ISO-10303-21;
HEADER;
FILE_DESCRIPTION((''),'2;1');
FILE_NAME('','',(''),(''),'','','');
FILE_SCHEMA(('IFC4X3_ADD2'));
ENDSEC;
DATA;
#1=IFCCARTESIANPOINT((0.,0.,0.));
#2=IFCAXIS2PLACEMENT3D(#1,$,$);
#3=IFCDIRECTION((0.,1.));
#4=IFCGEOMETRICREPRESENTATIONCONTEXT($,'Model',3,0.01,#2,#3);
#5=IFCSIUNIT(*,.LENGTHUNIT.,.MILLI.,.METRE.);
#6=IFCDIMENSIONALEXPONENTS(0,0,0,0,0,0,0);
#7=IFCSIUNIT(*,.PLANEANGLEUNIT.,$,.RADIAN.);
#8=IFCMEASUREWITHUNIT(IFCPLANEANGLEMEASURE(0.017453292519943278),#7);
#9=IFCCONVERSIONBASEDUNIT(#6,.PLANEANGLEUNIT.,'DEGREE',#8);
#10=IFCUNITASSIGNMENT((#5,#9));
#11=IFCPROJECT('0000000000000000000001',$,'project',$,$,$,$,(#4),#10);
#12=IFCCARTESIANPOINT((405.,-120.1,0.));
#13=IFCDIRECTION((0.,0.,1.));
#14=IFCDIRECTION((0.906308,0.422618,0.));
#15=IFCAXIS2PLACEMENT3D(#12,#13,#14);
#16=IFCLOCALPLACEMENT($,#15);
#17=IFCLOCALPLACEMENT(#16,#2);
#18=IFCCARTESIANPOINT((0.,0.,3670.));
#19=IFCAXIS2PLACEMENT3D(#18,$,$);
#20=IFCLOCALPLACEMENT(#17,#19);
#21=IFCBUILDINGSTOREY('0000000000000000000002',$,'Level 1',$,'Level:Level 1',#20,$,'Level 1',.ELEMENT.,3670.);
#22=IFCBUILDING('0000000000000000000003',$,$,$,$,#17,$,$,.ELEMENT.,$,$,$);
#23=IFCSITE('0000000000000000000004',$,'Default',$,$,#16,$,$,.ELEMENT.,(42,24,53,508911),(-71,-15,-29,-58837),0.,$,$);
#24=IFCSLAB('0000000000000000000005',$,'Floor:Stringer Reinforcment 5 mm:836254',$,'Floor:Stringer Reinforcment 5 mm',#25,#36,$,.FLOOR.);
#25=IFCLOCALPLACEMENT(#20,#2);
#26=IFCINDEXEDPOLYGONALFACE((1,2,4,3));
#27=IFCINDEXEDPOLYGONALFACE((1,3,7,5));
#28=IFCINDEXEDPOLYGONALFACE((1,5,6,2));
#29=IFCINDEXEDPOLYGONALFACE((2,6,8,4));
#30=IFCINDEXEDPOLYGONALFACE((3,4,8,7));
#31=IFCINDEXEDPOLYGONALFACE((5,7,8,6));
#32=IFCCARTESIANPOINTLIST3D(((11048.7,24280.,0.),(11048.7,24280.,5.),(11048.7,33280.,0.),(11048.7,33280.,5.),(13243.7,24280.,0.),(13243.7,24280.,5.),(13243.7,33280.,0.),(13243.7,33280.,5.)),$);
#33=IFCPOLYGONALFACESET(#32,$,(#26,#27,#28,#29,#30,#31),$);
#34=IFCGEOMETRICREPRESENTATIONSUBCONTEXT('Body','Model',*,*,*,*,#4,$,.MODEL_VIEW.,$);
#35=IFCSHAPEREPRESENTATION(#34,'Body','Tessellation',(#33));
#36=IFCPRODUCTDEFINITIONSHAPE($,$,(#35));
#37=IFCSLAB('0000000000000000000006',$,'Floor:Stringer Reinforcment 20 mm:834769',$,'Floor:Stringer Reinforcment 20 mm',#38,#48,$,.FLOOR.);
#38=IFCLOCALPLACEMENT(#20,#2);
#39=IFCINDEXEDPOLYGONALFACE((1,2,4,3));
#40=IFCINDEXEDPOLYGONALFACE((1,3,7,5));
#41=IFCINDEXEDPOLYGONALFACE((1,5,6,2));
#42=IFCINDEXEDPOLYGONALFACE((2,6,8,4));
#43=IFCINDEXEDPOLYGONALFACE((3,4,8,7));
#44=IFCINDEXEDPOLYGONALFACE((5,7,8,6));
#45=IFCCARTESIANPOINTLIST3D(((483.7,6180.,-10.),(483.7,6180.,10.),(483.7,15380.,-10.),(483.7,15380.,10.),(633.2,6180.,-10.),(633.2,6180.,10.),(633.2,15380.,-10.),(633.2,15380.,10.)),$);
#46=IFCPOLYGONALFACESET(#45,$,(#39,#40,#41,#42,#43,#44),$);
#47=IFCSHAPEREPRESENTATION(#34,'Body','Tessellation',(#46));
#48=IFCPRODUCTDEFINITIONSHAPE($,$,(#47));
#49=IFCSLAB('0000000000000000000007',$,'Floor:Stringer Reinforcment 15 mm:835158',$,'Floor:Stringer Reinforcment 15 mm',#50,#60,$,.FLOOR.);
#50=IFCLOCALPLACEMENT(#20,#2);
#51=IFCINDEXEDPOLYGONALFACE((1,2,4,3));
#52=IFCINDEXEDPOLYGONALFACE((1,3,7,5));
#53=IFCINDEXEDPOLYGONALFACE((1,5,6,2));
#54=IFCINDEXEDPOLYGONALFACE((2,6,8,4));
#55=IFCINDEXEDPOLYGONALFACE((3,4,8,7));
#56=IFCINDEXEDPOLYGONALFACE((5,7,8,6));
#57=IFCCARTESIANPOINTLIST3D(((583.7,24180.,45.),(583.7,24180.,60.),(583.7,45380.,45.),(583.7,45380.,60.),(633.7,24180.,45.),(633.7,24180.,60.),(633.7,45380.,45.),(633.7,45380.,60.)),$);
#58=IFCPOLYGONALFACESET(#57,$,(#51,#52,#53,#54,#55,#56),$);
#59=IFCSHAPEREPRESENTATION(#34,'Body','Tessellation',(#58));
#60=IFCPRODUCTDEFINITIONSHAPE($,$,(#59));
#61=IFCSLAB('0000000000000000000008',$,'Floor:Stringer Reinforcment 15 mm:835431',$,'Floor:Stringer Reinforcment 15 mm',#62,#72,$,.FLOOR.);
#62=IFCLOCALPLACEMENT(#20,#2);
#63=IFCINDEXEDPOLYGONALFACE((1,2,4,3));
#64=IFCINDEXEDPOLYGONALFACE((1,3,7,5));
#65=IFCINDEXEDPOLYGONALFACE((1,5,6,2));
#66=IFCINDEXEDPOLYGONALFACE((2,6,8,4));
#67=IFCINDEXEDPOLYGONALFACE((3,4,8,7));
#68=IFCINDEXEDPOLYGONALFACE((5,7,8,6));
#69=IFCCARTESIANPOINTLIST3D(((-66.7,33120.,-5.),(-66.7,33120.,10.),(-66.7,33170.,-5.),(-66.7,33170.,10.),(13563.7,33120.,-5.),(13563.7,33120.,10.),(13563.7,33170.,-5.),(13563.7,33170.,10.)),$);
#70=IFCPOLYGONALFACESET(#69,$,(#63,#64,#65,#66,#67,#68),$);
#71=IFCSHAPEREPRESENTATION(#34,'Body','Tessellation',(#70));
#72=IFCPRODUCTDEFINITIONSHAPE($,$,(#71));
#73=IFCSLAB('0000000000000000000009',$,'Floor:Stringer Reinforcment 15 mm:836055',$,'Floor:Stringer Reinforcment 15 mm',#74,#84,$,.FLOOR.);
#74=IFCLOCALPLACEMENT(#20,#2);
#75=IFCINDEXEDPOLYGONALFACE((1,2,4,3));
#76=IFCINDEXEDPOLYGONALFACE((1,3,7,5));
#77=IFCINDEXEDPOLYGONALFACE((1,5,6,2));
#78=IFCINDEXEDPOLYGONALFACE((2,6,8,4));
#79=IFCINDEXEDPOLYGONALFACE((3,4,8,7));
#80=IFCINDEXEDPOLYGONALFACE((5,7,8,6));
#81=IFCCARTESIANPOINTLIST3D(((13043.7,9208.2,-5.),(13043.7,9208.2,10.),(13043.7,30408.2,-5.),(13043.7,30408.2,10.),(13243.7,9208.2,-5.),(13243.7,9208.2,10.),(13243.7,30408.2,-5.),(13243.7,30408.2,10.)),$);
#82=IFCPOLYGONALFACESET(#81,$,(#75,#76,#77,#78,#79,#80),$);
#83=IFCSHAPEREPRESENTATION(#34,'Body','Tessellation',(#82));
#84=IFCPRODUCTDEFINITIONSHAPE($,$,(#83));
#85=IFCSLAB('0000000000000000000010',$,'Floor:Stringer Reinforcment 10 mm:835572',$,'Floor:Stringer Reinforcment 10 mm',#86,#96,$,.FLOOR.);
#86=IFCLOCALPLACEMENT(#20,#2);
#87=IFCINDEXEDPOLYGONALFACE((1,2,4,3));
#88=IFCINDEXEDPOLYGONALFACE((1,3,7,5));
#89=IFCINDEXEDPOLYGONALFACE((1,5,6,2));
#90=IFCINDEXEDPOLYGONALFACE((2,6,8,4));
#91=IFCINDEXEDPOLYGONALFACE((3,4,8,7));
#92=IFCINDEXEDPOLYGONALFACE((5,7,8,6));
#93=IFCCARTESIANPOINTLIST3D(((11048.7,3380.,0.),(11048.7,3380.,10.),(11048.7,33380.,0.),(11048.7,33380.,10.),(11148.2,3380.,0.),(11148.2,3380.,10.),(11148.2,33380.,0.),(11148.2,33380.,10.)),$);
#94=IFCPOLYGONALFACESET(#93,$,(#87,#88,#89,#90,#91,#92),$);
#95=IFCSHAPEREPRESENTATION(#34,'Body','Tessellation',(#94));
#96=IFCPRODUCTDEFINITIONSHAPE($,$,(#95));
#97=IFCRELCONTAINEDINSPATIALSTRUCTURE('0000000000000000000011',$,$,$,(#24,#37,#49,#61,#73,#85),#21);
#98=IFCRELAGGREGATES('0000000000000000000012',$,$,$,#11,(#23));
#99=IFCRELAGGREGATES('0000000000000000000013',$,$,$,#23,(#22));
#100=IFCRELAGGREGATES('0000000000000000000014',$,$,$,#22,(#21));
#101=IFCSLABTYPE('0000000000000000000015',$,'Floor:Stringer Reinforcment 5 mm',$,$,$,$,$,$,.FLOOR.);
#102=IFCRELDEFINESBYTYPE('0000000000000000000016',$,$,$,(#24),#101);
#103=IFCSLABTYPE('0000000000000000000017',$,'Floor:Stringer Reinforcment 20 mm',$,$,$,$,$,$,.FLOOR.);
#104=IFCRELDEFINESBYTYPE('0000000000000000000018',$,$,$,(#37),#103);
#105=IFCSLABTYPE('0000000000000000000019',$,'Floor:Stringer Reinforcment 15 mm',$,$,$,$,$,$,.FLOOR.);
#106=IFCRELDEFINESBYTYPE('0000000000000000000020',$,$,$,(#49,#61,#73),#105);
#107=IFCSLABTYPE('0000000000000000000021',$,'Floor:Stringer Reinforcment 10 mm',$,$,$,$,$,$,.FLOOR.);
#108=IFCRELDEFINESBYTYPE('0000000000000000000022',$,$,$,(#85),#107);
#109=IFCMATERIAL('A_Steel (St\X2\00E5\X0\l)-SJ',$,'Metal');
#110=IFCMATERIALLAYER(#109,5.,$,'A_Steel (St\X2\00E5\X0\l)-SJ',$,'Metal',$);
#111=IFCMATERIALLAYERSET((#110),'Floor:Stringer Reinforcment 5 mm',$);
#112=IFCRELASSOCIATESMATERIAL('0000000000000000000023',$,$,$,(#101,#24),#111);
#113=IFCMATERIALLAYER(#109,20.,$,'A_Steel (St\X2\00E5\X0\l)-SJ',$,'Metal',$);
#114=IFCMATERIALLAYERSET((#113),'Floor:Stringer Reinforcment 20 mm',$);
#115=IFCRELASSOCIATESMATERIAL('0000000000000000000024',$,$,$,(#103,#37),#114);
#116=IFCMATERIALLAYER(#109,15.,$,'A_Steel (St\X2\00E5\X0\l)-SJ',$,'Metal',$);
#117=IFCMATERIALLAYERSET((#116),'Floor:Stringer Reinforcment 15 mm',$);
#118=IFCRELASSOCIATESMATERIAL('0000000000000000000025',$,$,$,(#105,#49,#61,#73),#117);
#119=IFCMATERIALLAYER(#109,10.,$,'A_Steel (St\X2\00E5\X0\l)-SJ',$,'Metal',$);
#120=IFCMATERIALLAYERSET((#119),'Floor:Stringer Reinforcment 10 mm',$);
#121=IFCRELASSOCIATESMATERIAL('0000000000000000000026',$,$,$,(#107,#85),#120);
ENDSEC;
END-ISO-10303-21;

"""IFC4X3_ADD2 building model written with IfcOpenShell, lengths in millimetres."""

from ifc_helpers import new_model, entity, si_unit, converted_unit, direction, frame, frame_2d, origin, origin_2d_with_axis, place, context, subcontext, project, spatial, rectangle, extrude, material, layer, layer_set, layer_usage, type_object, element, save


model = new_model("IFC4X3_ADD2")

# Units and contexts
model_context = context("Model", 3, precision=0.01, world=origin(), true_north=direction((0.0, 1.0)))
body_context = subcontext(model_context, "Body", "Model", "MODEL_VIEW")
ifc_project = project(units=[si_unit("LENGTHUNIT", "METRE", prefix="MILLI"), converted_unit("PLANEANGLEUNIT", "DEGREE", entity("IfcPlaneAngleMeasure", 0.017453292519943278), si_unit("PLANEANGLEUNIT", "RADIAN"), dimensions=[0, 0, 0, 0, 0, 0, 0])], contexts=[model_context])

# Site, building, storey
site_placement = place(None, frame((405.0, -120.1, 0.0), z_axis=(0.0, 0.0, 1.0), x_axis=(0.906308, 0.422618, 0.0)))
site = spatial("IfcSite", under=ifc_project, at=site_placement, Name="Default", CompositionType="ELEMENT", RefLatitude=(42, 24, 53, 508911), RefLongitude=(-71, -15, -29, -58837), RefElevation=0.0)
building_placement = place(site_placement, origin())
building = spatial("IfcBuilding", under=site, at=building_placement, CompositionType="ELEMENT")
storey_placement = place(building_placement, frame((0.0, 0.0, 3670.0)))
storey = spatial("IfcBuildingStorey", under=building, at=storey_placement, Name="Level 1", ObjectType="Level:Level 1", LongName="Level 1", CompositionType="ELEMENT", Elevation=3670.0)

# Slabs
ifc_material_1 = material(Name="A_Steel (Stål)-SJ", Category="Metal")
ifc_layer_1 = layer(ifc_material_1, 5.0, Name="A_Steel (Stål)-SJ", Category="Metal")
ifc_layer_set_1 = layer_set([ifc_layer_1], Name="Floor:Stringer Reinforcment 5 mm")
slab_type_1 = type_object("IfcSlabType", Name="Floor:Stringer Reinforcment 5 mm", PredefinedType="FLOOR", material=ifc_layer_set_1)
ifc_layer_usage_1 = layer_usage(ifc_layer_set_1, "AXIS3", "POSITIVE", 0.0)
slab_1_placement = place(storey_placement, origin())
element("IfcSlab", 1, at=slab_1_placement, inside=storey, type_object=slab_type_1, material=ifc_layer_usage_1, Name="Floor:Stringer Reinforcment 5 mm:836254", ObjectType="Floor:Stringer Reinforcment 5 mm", PredefinedType="FLOOR", context=body_context, shape_type="SweptSolid", body=[
    extrude(rectangle(XDim=9000.0, YDim=2195.0, at=frame_2d((0.0, 0.0), x_axis=(1.0, 0.0))), frame((12146.2, 28780.0, 5.0), z_axis=(0.0, 0.0, -1.0), x_axis=(0.0, 1.0, 0.0)), (0.0, 0.0, 1.0), 5.0),
])
ifc_layer_2 = layer(ifc_material_1, 20.0, Name="A_Steel (Stål)-SJ", Category="Metal")
ifc_layer_set_2 = layer_set([ifc_layer_2], Name="Floor:Stringer Reinforcment 20 mm")
ifc_layer_usage_2 = layer_usage(ifc_layer_set_2, "AXIS3", "POSITIVE", 0.0)
slab_type_2 = type_object("IfcSlabType", Name="Floor:Stringer Reinforcment 20 mm", PredefinedType="FLOOR", material=ifc_layer_set_2)
slab_2_placement = place(storey_placement, origin())
element("IfcSlab", 2, at=slab_2_placement, inside=storey, type_object=slab_type_2, material=ifc_layer_usage_2, Name="Floor:Stringer Reinforcment 20 mm:834769", ObjectType="Floor:Stringer Reinforcment 20 mm", PredefinedType="FLOOR", context=body_context, shape_type="SweptSolid", body=[
    extrude(rectangle(XDim=9200.0, YDim=149.5, at=frame_2d((0.0, 0.0), x_axis=(1.0, 0.0))), frame((558.5, 10780.0, 10.0), z_axis=(0.0, 0.0, -1.0), x_axis=(0.0, 1.0, 0.0)), (0.0, 0.0, 1.0), 20.0),
])
ifc_layer_3 = layer(ifc_material_1, 15.0, Name="A_Steel (Stål)-SJ", Category="Metal")
ifc_layer_set_3 = layer_set([ifc_layer_3], Name="Floor:Stringer Reinforcment 15 mm")
ifc_layer_usage_3 = layer_usage(ifc_layer_set_3, "AXIS3", "POSITIVE", 0.0)
slab_type_3 = type_object("IfcSlabType", Name="Floor:Stringer Reinforcment 15 mm", PredefinedType="FLOOR", material=ifc_layer_set_3)
slab_3_placement = place(storey_placement, origin())
element("IfcSlab", 3, at=slab_3_placement, inside=storey, type_object=slab_type_3, material=ifc_layer_usage_3, Name="Floor:Stringer Reinforcment 15 mm:835158", ObjectType="Floor:Stringer Reinforcment 15 mm", PredefinedType="FLOOR", context=body_context, shape_type="SweptSolid", body=[
    extrude(rectangle(XDim=21200.0, YDim=50.0, at=frame_2d((0.0, 0.0), x_axis=(1.0, 0.0))), frame((608.7, 34780.0, 60.0), z_axis=(0.0, 0.0, -1.0), x_axis=(0.0, 1.0, 0.0)), (0.0, 0.0, 1.0), 15.0),
])
ifc_layer_usage_4 = layer_usage(ifc_layer_set_3, "AXIS3", "POSITIVE", 0.0)
slab_4_placement = place(storey_placement, origin())
element("IfcSlab", 4, at=slab_4_placement, inside=storey, type_object=slab_type_3, material=ifc_layer_usage_4, Name="Floor:Stringer Reinforcment 15 mm:835431", ObjectType="Floor:Stringer Reinforcment 15 mm", PredefinedType="FLOOR", context=body_context, shape_type="SweptSolid", body=[
    extrude(rectangle(XDim=50.0, YDim=13630.4, at=frame_2d((0.0, 0.0), x_axis=(1.0, 0.0))), frame((6748.5, 33145.0, 10.0), z_axis=(0.0, 0.0, -1.0), x_axis=(0.0, 1.0, 0.0)), (0.0, 0.0, 1.0), 15.0),
])
ifc_layer_usage_5 = layer_usage(ifc_layer_set_3, "AXIS3", "POSITIVE", 0.0)
slab_5_placement = place(storey_placement, origin())
element("IfcSlab", 5, at=slab_5_placement, inside=storey, type_object=slab_type_3, material=ifc_layer_usage_5, Name="Floor:Stringer Reinforcment 15 mm:836055", ObjectType="Floor:Stringer Reinforcment 15 mm", PredefinedType="FLOOR", context=body_context, shape_type="SweptSolid", body=[
    extrude(rectangle(XDim=21200.0, YDim=200.0, at=origin_2d_with_axis()), frame((13143.7, 19808.2, 10.0), z_axis=(0.0, 0.0, -1.0), x_axis=(0.0, 1.0, 0.0)), (0.0, 0.0, 1.0), 15.0),
])
ifc_layer_4 = layer(ifc_material_1, 10.0, Name="A_Steel (Stål)-SJ", Category="Metal")
ifc_layer_set_4 = layer_set([ifc_layer_4], Name="Floor:Stringer Reinforcment 10 mm")
ifc_layer_usage_6 = layer_usage(ifc_layer_set_4, "AXIS3", "POSITIVE", 0.0)
slab_type_4 = type_object("IfcSlabType", Name="Floor:Stringer Reinforcment 10 mm", PredefinedType="FLOOR", material=ifc_layer_set_4)
slab_6_placement = place(storey_placement, origin())
element("IfcSlab", 6, at=slab_6_placement, inside=storey, type_object=slab_type_4, material=ifc_layer_usage_6, Name="Floor:Stringer Reinforcment 10 mm:835572", ObjectType="Floor:Stringer Reinforcment 10 mm", PredefinedType="FLOOR", context=body_context, shape_type="SweptSolid", body=[
    extrude(rectangle(XDim=30000.0, YDim=99.5, at=origin_2d_with_axis()), frame((11098.5, 18380.0, 10.0), z_axis=(0.0, 0.0, -1.0), x_axis=(0.0, 1.0, 0.0)), (0.0, 0.0, 1.0), 10.0),
])

save(model, "model.ifc")
